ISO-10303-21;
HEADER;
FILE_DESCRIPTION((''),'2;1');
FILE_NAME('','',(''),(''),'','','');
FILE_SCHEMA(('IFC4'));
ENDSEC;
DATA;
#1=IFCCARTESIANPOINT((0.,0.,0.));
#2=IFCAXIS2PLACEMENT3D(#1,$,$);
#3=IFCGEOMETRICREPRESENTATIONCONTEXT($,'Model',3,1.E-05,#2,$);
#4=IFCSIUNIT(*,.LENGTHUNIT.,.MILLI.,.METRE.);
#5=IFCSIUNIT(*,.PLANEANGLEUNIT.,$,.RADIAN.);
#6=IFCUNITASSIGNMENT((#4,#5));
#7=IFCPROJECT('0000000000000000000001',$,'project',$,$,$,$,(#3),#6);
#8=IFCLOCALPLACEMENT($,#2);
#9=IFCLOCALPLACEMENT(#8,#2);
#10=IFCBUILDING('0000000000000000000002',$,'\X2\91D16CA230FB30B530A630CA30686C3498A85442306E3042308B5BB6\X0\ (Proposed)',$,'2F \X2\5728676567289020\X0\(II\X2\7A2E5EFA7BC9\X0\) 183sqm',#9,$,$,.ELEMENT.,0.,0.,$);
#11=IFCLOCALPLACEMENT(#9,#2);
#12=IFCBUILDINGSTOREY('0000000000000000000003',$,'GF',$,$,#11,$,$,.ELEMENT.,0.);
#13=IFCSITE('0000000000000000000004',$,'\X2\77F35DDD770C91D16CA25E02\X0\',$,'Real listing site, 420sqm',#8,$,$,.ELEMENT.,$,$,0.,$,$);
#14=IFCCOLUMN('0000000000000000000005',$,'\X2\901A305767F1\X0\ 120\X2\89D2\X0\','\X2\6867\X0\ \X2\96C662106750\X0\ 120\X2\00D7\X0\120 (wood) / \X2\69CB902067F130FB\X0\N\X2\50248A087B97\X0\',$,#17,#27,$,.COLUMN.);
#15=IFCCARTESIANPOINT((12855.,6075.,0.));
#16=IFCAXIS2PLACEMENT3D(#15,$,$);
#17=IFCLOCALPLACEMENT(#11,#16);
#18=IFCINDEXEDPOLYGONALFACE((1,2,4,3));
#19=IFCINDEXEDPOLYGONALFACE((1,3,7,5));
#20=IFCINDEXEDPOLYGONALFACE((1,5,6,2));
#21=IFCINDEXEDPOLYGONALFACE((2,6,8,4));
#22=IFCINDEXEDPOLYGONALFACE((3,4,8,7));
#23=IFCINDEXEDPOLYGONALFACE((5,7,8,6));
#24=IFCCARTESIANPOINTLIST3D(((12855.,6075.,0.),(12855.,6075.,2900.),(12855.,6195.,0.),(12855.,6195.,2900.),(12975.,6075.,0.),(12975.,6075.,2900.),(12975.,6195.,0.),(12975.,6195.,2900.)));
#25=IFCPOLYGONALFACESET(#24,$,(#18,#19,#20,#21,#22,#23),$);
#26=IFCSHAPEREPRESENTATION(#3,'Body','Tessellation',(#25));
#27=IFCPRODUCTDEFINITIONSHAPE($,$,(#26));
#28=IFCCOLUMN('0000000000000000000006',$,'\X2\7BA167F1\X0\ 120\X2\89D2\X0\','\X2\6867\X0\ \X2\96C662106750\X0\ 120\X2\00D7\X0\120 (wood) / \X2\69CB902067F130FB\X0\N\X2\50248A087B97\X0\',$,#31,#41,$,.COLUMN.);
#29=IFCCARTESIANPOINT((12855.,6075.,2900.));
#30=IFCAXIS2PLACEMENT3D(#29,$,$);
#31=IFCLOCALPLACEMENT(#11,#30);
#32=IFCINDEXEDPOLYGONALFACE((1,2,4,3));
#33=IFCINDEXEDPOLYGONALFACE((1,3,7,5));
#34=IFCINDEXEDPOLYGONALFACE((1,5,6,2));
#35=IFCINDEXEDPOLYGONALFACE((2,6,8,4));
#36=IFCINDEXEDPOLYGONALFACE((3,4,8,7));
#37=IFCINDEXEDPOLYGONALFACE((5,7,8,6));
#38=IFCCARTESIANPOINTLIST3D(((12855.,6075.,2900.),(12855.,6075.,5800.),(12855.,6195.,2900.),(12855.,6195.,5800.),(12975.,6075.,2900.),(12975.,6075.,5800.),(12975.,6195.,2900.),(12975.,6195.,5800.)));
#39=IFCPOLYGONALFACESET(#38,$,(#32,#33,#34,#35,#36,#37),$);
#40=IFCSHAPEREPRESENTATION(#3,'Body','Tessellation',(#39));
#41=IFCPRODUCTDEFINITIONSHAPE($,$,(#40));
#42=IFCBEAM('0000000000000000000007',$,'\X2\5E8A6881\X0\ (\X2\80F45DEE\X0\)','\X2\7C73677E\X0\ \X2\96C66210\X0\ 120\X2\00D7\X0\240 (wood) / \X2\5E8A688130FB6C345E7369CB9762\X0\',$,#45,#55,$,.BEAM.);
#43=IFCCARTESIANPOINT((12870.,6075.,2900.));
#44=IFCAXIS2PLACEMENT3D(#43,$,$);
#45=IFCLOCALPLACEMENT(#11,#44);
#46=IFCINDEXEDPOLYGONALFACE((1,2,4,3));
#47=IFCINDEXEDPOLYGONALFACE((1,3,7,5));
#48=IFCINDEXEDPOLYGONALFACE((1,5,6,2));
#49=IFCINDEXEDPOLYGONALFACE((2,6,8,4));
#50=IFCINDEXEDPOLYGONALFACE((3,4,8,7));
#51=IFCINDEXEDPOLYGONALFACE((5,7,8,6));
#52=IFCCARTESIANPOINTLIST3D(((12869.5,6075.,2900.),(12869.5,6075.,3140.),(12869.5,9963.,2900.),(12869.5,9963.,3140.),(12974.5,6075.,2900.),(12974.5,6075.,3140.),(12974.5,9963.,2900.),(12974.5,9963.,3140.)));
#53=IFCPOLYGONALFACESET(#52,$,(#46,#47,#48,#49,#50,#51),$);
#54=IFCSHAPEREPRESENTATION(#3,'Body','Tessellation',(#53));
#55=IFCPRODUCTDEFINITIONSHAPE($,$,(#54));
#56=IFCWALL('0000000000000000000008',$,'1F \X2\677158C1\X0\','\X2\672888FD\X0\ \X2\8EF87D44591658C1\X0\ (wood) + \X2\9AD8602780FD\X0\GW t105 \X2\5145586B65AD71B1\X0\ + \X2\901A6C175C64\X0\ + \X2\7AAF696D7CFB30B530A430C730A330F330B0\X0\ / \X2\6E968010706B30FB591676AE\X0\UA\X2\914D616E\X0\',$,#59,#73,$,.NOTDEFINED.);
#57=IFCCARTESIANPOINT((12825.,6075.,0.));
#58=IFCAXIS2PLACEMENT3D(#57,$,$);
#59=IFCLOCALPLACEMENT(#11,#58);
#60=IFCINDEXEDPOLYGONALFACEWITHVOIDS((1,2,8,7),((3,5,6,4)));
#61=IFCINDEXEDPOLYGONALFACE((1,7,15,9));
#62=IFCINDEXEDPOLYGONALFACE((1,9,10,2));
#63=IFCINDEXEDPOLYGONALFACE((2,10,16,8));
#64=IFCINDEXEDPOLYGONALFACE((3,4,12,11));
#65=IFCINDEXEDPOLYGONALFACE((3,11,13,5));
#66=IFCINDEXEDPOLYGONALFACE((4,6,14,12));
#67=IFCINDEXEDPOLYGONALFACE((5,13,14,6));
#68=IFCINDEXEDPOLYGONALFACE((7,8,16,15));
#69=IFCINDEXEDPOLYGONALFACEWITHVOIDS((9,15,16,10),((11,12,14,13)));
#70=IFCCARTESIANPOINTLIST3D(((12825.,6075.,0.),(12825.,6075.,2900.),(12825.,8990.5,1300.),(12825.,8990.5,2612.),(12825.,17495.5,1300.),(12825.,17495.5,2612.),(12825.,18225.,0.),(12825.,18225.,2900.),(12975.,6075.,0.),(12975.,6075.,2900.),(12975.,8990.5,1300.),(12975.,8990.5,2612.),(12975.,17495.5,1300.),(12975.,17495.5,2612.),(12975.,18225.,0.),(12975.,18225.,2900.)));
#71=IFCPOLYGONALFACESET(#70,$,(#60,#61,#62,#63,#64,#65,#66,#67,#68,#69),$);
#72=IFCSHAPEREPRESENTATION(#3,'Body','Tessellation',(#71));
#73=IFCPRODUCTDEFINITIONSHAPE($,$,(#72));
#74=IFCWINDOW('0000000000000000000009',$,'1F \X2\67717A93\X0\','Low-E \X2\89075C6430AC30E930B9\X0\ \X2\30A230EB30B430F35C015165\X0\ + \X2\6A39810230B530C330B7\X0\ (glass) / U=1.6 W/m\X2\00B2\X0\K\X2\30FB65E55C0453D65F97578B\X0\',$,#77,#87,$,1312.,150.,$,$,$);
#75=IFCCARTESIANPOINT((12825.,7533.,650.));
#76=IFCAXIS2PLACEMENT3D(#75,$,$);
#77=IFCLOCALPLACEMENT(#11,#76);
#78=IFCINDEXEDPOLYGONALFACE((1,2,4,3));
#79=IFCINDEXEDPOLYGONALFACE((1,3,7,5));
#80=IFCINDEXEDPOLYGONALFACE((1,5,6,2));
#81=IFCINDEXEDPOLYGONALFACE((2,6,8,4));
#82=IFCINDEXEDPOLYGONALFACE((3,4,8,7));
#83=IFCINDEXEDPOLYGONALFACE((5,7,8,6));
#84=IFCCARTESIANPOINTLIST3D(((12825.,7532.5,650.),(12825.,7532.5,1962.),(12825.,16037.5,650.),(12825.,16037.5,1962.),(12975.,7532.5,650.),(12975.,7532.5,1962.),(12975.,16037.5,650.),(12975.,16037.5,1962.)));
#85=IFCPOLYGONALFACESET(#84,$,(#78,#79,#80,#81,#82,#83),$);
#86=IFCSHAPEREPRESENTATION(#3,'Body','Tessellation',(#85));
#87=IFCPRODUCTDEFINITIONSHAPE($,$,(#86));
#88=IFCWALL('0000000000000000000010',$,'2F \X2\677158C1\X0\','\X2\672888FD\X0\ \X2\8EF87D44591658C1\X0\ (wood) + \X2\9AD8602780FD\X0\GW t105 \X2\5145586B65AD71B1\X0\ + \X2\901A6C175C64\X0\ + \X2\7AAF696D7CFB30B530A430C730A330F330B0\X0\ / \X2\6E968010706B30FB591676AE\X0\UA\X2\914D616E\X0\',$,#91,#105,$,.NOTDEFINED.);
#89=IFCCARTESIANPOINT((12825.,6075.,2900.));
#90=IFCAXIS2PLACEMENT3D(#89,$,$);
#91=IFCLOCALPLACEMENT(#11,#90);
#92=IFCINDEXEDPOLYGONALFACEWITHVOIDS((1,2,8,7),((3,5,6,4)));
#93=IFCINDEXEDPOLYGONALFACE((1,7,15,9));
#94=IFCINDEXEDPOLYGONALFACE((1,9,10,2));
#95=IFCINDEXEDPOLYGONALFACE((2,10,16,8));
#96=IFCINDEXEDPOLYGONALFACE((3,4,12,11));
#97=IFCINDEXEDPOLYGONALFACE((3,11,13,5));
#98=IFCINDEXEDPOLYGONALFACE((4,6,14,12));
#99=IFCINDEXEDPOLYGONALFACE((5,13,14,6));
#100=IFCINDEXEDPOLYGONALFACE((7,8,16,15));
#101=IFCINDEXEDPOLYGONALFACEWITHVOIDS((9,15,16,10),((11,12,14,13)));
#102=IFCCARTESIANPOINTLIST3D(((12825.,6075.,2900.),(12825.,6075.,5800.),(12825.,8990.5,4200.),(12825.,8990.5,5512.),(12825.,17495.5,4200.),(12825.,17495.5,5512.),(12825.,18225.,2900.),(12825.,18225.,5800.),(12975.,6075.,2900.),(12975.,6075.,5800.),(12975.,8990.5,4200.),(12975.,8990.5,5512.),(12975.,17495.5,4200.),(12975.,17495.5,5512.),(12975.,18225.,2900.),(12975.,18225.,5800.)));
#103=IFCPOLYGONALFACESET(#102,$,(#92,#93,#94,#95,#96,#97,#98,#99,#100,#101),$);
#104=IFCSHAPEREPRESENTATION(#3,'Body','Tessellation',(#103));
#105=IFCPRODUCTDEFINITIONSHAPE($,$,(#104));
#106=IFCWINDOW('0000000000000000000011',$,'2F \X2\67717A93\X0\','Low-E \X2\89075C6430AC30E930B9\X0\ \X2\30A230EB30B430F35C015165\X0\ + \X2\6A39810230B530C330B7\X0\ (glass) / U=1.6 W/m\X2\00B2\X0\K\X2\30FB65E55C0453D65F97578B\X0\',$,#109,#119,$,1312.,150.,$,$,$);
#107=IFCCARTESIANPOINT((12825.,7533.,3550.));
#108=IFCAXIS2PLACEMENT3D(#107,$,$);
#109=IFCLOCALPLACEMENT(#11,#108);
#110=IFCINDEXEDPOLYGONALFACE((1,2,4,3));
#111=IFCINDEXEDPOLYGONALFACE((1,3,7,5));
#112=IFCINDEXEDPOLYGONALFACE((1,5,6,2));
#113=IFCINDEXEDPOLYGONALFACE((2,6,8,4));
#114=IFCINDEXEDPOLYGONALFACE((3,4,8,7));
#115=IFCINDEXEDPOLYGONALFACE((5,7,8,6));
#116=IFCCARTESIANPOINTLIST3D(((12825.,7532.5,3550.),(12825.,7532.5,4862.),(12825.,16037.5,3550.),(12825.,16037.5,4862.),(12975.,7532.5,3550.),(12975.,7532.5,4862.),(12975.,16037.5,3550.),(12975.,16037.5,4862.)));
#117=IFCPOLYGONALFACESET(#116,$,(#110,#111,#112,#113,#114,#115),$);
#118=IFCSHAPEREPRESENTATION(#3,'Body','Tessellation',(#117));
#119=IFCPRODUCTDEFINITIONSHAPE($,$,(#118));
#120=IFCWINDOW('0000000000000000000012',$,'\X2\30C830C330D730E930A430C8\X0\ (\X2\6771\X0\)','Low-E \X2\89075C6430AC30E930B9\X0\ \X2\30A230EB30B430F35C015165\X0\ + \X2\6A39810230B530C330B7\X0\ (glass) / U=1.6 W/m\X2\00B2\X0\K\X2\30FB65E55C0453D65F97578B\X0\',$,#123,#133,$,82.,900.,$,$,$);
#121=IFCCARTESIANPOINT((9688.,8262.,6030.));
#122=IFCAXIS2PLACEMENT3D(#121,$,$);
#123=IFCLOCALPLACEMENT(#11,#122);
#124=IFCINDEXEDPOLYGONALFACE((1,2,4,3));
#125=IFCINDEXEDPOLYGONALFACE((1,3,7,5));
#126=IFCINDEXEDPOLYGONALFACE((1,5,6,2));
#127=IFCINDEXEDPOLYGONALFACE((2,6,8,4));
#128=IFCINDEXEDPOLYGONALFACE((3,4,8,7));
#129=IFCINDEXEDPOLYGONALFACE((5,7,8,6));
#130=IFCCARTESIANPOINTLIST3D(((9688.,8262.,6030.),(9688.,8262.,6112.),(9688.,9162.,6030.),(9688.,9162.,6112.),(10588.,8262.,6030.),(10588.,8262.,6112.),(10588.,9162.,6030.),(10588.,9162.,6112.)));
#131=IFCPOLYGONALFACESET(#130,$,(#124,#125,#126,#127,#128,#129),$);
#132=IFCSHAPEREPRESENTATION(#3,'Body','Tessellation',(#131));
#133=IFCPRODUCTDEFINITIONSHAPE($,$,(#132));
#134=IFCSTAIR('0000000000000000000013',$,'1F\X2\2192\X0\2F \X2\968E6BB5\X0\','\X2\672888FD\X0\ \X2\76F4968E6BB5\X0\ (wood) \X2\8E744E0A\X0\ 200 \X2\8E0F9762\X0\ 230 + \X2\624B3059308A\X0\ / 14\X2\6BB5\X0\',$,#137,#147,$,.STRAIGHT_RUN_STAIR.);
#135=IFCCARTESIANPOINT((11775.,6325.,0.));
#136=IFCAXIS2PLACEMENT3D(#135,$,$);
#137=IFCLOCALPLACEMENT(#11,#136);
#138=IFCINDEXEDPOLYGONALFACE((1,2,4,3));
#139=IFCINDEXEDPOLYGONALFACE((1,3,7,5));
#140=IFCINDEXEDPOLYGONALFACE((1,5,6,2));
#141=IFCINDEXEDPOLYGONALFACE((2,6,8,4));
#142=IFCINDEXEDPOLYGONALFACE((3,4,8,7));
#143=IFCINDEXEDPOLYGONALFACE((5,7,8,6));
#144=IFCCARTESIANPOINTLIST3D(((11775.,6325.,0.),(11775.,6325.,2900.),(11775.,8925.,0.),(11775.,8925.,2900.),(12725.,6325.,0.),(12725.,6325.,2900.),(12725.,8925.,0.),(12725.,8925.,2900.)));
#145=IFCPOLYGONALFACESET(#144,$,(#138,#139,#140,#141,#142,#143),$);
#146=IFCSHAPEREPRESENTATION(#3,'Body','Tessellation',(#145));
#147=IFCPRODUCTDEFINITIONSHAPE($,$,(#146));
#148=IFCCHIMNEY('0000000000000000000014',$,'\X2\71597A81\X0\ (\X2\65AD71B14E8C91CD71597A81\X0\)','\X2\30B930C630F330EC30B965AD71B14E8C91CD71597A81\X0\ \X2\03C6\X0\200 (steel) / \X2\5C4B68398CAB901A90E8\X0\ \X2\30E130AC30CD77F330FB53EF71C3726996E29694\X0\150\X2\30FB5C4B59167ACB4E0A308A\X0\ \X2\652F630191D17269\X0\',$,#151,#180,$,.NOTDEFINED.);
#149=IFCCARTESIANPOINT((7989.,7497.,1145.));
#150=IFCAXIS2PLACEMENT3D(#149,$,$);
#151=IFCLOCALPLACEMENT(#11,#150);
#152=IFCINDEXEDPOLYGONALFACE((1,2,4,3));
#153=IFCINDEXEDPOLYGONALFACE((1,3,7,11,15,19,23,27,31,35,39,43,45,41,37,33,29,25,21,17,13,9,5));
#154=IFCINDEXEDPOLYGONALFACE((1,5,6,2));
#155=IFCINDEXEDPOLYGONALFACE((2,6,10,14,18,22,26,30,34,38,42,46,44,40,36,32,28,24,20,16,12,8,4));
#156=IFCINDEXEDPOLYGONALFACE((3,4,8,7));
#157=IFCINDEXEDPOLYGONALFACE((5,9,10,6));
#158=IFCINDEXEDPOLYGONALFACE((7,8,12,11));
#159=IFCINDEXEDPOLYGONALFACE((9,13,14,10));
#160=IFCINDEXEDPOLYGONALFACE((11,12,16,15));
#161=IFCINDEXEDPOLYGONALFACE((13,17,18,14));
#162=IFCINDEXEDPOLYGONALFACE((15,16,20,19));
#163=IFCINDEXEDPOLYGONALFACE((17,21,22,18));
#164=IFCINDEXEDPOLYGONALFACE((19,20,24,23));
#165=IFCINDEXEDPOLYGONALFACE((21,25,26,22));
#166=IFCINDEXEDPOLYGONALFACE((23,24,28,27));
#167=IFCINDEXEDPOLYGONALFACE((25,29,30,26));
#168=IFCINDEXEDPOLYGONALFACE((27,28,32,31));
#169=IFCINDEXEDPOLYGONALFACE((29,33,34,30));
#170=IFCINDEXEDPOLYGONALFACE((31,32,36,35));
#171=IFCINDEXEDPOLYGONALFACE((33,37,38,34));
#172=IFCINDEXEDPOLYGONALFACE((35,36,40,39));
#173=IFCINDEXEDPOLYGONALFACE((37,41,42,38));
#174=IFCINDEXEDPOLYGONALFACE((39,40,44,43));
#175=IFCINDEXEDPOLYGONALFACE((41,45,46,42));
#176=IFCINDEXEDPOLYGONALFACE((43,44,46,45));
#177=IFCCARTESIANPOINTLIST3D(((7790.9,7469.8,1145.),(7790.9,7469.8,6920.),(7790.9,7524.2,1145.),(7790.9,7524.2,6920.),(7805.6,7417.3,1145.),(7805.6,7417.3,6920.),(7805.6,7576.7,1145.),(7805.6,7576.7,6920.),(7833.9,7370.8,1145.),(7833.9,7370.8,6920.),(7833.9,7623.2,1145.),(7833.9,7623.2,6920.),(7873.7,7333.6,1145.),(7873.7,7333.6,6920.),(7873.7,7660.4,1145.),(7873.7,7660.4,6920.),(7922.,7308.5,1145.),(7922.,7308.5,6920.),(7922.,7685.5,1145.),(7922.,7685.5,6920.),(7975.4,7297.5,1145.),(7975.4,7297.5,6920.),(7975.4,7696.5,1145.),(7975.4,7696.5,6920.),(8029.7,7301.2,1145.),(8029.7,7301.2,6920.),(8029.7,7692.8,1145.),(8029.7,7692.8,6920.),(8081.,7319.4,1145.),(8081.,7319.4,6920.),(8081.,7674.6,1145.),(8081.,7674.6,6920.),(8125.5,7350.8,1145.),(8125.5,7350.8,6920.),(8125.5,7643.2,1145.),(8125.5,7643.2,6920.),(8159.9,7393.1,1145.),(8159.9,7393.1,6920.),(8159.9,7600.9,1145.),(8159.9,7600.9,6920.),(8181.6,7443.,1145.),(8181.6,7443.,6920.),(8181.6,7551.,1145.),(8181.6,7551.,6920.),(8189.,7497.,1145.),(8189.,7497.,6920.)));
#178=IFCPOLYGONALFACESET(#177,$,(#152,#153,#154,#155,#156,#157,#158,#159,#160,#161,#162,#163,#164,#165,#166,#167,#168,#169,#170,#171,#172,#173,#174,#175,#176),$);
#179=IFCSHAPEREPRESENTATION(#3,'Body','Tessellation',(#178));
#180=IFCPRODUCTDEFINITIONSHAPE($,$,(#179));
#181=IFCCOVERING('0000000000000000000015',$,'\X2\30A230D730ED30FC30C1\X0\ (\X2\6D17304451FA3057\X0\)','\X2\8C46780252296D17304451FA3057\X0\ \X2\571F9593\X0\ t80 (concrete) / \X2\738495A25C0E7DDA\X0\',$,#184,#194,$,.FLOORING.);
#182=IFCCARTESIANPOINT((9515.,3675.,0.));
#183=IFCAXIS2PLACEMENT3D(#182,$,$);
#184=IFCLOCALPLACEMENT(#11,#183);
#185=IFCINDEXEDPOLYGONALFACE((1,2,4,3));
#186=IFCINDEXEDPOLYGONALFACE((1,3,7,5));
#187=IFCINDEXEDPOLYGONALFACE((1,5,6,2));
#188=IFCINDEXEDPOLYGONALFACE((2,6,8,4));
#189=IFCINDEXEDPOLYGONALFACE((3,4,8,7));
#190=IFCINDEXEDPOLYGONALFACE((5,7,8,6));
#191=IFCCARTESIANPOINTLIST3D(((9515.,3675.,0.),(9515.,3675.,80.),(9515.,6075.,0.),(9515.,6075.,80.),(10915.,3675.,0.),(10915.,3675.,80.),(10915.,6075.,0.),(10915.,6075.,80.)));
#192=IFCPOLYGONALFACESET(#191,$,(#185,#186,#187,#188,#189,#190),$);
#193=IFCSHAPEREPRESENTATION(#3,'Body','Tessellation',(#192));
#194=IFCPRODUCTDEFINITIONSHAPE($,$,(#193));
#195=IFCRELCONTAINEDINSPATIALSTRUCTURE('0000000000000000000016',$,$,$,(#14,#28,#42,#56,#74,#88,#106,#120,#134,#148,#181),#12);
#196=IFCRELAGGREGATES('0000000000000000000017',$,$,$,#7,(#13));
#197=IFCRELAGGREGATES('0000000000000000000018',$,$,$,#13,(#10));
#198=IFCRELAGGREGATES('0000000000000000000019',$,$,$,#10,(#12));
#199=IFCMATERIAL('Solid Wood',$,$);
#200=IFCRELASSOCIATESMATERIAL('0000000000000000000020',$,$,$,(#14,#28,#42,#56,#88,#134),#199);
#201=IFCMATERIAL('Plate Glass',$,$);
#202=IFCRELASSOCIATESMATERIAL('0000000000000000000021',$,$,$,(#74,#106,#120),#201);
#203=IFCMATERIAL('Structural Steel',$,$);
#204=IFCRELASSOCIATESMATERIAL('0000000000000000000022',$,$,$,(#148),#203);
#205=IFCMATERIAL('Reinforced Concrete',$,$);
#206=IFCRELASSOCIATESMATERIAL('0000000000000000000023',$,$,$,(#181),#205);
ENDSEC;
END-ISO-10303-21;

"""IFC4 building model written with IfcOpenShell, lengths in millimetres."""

from ifc_helpers import new_model, si_unit, frame, frame_2d, origin, origin_2d, place, context, project, spatial, rectangle, circle, extrude, material, element, fill, save


model = new_model("IFC4")

# Units and contexts
model_context = context("Model", 3, precision=1e-05, world=origin())
ifc_project = project(units=[si_unit("LENGTHUNIT", "METRE", prefix="MILLI"), si_unit("PLANEANGLEUNIT", "RADIAN")], contexts=[model_context])

# Site, building, storey
site_placement = place(None, origin())
site = spatial("IfcSite", under=ifc_project, at=site_placement, Name="石川県金沢市", ObjectType="Real listing site, 420sqm", CompositionType="ELEMENT", RefElevation=0.0)
building_placement = place(site_placement, origin())
building = spatial("IfcBuilding", under=site, at=building_placement, Name="金沢・サウナと水風呂のある家 (Proposed)", ObjectType="2F 在来木造(II種建築) 183sqm", CompositionType="ELEMENT", ElevationOfRefHeight=0.0, ElevationOfTerrain=0.0)
storey_placement = place(building_placement, origin())
storey = spatial("IfcBuildingStorey", under=building, at=storey_placement, Name="GF", CompositionType="ELEMENT", Elevation=0.0)

# Columns
ifc_material_1 = material(Name="Solid Wood")
column_1_placement = place(storey_placement, frame((12855.0, 6075.0, 0.0)))
element("IfcColumn", 1, at=column_1_placement, inside=storey, material=ifc_material_1, Name="通し柱 120角", Description="桧 集成材 120×120 (wood) / 構造柱・N値計算", PredefinedType="COLUMN", context=model_context, shape_type="SweptSolid", body=[
    extrude(rectangle(XDim=120.0, YDim=120.0, at=frame_2d((60.0, 60.0))), frame((12855.0, 6075.0, 0.0)), (0.0, 0.0, 1.0), 2900.0),
])
column_2_placement = place(storey_placement, frame((12855.0, 6075.0, 2900.0)))
element("IfcColumn", 2, at=column_2_placement, inside=storey, material=ifc_material_1, Name="管柱 120角", Description="桧 集成材 120×120 (wood) / 構造柱・N値計算", PredefinedType="COLUMN", context=model_context, shape_type="SweptSolid", body=[
    extrude(rectangle(XDim=120.0, YDim=120.0, at=frame_2d((60.0, 60.0))), frame((12855.0, 6075.0, 2900.0)), (0.0, 0.0, 1.0), 2900.0),
])

# Beam
beam_1_placement = place(storey_placement, frame((12870.0, 6075.0, 2900.0)))
element("IfcBeam", 3, at=beam_1_placement, inside=storey, material=ifc_material_1, Name="床梁 (胴差)", Description="米松 集成 120×240 (wood) / 床梁・水平構面", PredefinedType="BEAM", context=model_context, shape_type="SweptSolid", body=[
    extrude(rectangle(XDim=105.0, YDim=3888.0, at=frame_2d((52.0, 1944.0))), frame((12870.0, 6075.0, 2900.0)), (0.0, 0.0, 1.0), 240.0),
])

# Wall, opening, window
wall_1_placement = place(storey_placement, frame((12825.0, 6075.0, 0.0)))
wall_1 = element("IfcWall", 4, at=wall_1_placement, inside=storey, material=ifc_material_1, Name="1F 東壁", Description="木製 軸組外壁 (wood) + 高性能GW t105 充填断熱 + 通気層 + 窯業系サイディング / 準耐火・外皮UA配慮", PredefinedType="NOTDEFINED", context=model_context, shape_type="SweptSolid", body=[
    extrude(rectangle(XDim=150.0, YDim=12150.0, at=frame_2d((75.0, 6075.0))), frame((12825.0, 6075.0, 0.0)), (0.0, 0.0, 1.0), 2900.0),
])
opening_1_placement = place(storey_placement, frame((12825.0, 7533.0, 650.0)))
opening_1 = element("IfcOpeningElement", 5, at=opening_1_placement, cuts=wall_1, PredefinedType="NOTDEFINED", context=model_context, shape_type="SweptSolid", body=[
    extrude(rectangle(XDim=150.0, YDim=8505.0, at=frame_2d((75.0, 4252.0))), frame((12825.0, 7533.0, 650.0)), (0.0, 0.0, 1.0), 1312.0),
])
ifc_material_2 = material(Name="Plate Glass")
window_1_placement = place(storey_placement, frame((12825.0, 7533.0, 650.0)))
window_1 = element("IfcWindow", 6, at=window_1_placement, inside=storey, material=ifc_material_2, Name="1F 東窓", Description="Low-E 複層ガラス アルゴン封入 + 樹脂サッシ (glass) / U=1.6 W/m²K・日射取得型", OverallHeight=1312.0, OverallWidth=150.0, context=model_context, shape_type="SweptSolid", body=[
    extrude(rectangle(XDim=150.0, YDim=8505.0, at=frame_2d((75.0, 4252.0))), frame((12825.0, 7533.0, 650.0)), (0.0, 0.0, 1.0), 1312.0),
])
fill(opening_1, window_1)

# Wall, opening, window
wall_2_placement = place(storey_placement, frame((12825.0, 6075.0, 2900.0)))
wall_2 = element("IfcWall", 7, at=wall_2_placement, inside=storey, material=ifc_material_1, Name="2F 東壁", Description="木製 軸組外壁 (wood) + 高性能GW t105 充填断熱 + 通気層 + 窯業系サイディング / 準耐火・外皮UA配慮", PredefinedType="NOTDEFINED", context=model_context, shape_type="SweptSolid", body=[
    extrude(rectangle(XDim=150.0, YDim=12150.0, at=frame_2d((75.0, 6075.0))), frame((12825.0, 6075.0, 2900.0)), (0.0, 0.0, 1.0), 2900.0),
])
opening_2_placement = place(storey_placement, frame((12825.0, 7533.0, 3550.0)))
opening_2 = element("IfcOpeningElement", 8, at=opening_2_placement, cuts=wall_2, PredefinedType="NOTDEFINED", context=model_context, shape_type="SweptSolid", body=[
    extrude(rectangle(XDim=150.0, YDim=8505.0, at=frame_2d((75.0, 4252.0))), frame((12825.0, 7533.0, 3550.0)), (0.0, 0.0, 1.0), 1312.0),
])
window_2_placement = place(storey_placement, frame((12825.0, 7533.0, 3550.0)))
window_2 = element("IfcWindow", 9, at=window_2_placement, inside=storey, material=ifc_material_2, Name="2F 東窓", Description="Low-E 複層ガラス アルゴン封入 + 樹脂サッシ (glass) / U=1.6 W/m²K・日射取得型", OverallHeight=1312.0, OverallWidth=150.0, context=model_context, shape_type="SweptSolid", body=[
    extrude(rectangle(XDim=150.0, YDim=8505.0, at=frame_2d((75.0, 4252.0))), frame((12825.0, 7533.0, 3550.0)), (0.0, 0.0, 1.0), 1312.0),
])
fill(opening_2, window_2)

# Window
window_3_placement = place(storey_placement, frame((9688.0, 8262.0, 6030.0)))
element("IfcWindow", 10, at=window_3_placement, inside=storey, material=ifc_material_2, Name="トップライト (東)", Description="Low-E 複層ガラス アルゴン封入 + 樹脂サッシ (glass) / U=1.6 W/m²K・日射取得型", OverallHeight=82.0, OverallWidth=900.0, context=model_context, shape_type="SweptSolid", body=[
    extrude(rectangle(XDim=900.0, YDim=900.0, at=frame_2d((450.0, 450.0))), frame((9688.0, 8262.0, 6030.0)), (0.0, 0.0, 1.0), 82.0),
])

# Stair
stair_placement = place(storey_placement, frame((11775.0, 6325.0, 0.0)))
element("IfcStair", 11, at=stair_placement, inside=storey, material=ifc_material_1, Name="1F→2F 階段", Description="木製 直階段 (wood) 蹴上 200 踏面 230 + 手すり / 14段", PredefinedType="STRAIGHT_RUN_STAIR", context=model_context, shape_type="SweptSolid", body=[
    extrude(rectangle(XDim=950.0, YDim=2600.0, at=frame_2d((475.0, 1300.0))), frame((11775.0, 6325.0, 0.0)), (0.0, 0.0, 1.0), 2900.0),
])

# Chimney
ifc_material_3 = material(Name="Structural Steel")
chimney_placement = place(storey_placement, frame((7989.0, 7497.0, 1145.0)))
element("IfcChimney", 12, at=chimney_placement, inside=storey, material=ifc_material_3, Name="煙突 (断熱二重煙突)", Description="ステンレス断熱二重煙突 φ200 (steel) / 屋根貫通部 メガネ石・可燃物離隔150・屋外立上り 支持金物", PredefinedType="NOTDEFINED", context=model_context, shape_type="SweptSolid", body=[
    extrude(circle(Radius=200.0, at=origin_2d()), frame((7989.0, 7497.0, 1145.0)), (0.0, 0.0, 1.0), 5775.0),
])

# Covering
ifc_material_4 = material(Name="Reinforced Concrete")
covering_1_placement = place(storey_placement, frame((9515.0, 3675.0, 0.0)))
element("IfcCovering", 13, at=covering_1_placement, inside=storey, material=ifc_material_4, Name="アプローチ (洗い出し)", Description="豆砂利洗い出し 土間 t80 (concrete) / 玄関導線", PredefinedType="FLOORING", context=model_context, shape_type="SweptSolid", body=[
    extrude(rectangle(XDim=1400.0, YDim=2400.0, at=frame_2d((700.0, 1200.0))), frame((9515.0, 3675.0, 0.0)), (0.0, 0.0, 1.0), 80.0),
])

save(model, "model.ifc")
